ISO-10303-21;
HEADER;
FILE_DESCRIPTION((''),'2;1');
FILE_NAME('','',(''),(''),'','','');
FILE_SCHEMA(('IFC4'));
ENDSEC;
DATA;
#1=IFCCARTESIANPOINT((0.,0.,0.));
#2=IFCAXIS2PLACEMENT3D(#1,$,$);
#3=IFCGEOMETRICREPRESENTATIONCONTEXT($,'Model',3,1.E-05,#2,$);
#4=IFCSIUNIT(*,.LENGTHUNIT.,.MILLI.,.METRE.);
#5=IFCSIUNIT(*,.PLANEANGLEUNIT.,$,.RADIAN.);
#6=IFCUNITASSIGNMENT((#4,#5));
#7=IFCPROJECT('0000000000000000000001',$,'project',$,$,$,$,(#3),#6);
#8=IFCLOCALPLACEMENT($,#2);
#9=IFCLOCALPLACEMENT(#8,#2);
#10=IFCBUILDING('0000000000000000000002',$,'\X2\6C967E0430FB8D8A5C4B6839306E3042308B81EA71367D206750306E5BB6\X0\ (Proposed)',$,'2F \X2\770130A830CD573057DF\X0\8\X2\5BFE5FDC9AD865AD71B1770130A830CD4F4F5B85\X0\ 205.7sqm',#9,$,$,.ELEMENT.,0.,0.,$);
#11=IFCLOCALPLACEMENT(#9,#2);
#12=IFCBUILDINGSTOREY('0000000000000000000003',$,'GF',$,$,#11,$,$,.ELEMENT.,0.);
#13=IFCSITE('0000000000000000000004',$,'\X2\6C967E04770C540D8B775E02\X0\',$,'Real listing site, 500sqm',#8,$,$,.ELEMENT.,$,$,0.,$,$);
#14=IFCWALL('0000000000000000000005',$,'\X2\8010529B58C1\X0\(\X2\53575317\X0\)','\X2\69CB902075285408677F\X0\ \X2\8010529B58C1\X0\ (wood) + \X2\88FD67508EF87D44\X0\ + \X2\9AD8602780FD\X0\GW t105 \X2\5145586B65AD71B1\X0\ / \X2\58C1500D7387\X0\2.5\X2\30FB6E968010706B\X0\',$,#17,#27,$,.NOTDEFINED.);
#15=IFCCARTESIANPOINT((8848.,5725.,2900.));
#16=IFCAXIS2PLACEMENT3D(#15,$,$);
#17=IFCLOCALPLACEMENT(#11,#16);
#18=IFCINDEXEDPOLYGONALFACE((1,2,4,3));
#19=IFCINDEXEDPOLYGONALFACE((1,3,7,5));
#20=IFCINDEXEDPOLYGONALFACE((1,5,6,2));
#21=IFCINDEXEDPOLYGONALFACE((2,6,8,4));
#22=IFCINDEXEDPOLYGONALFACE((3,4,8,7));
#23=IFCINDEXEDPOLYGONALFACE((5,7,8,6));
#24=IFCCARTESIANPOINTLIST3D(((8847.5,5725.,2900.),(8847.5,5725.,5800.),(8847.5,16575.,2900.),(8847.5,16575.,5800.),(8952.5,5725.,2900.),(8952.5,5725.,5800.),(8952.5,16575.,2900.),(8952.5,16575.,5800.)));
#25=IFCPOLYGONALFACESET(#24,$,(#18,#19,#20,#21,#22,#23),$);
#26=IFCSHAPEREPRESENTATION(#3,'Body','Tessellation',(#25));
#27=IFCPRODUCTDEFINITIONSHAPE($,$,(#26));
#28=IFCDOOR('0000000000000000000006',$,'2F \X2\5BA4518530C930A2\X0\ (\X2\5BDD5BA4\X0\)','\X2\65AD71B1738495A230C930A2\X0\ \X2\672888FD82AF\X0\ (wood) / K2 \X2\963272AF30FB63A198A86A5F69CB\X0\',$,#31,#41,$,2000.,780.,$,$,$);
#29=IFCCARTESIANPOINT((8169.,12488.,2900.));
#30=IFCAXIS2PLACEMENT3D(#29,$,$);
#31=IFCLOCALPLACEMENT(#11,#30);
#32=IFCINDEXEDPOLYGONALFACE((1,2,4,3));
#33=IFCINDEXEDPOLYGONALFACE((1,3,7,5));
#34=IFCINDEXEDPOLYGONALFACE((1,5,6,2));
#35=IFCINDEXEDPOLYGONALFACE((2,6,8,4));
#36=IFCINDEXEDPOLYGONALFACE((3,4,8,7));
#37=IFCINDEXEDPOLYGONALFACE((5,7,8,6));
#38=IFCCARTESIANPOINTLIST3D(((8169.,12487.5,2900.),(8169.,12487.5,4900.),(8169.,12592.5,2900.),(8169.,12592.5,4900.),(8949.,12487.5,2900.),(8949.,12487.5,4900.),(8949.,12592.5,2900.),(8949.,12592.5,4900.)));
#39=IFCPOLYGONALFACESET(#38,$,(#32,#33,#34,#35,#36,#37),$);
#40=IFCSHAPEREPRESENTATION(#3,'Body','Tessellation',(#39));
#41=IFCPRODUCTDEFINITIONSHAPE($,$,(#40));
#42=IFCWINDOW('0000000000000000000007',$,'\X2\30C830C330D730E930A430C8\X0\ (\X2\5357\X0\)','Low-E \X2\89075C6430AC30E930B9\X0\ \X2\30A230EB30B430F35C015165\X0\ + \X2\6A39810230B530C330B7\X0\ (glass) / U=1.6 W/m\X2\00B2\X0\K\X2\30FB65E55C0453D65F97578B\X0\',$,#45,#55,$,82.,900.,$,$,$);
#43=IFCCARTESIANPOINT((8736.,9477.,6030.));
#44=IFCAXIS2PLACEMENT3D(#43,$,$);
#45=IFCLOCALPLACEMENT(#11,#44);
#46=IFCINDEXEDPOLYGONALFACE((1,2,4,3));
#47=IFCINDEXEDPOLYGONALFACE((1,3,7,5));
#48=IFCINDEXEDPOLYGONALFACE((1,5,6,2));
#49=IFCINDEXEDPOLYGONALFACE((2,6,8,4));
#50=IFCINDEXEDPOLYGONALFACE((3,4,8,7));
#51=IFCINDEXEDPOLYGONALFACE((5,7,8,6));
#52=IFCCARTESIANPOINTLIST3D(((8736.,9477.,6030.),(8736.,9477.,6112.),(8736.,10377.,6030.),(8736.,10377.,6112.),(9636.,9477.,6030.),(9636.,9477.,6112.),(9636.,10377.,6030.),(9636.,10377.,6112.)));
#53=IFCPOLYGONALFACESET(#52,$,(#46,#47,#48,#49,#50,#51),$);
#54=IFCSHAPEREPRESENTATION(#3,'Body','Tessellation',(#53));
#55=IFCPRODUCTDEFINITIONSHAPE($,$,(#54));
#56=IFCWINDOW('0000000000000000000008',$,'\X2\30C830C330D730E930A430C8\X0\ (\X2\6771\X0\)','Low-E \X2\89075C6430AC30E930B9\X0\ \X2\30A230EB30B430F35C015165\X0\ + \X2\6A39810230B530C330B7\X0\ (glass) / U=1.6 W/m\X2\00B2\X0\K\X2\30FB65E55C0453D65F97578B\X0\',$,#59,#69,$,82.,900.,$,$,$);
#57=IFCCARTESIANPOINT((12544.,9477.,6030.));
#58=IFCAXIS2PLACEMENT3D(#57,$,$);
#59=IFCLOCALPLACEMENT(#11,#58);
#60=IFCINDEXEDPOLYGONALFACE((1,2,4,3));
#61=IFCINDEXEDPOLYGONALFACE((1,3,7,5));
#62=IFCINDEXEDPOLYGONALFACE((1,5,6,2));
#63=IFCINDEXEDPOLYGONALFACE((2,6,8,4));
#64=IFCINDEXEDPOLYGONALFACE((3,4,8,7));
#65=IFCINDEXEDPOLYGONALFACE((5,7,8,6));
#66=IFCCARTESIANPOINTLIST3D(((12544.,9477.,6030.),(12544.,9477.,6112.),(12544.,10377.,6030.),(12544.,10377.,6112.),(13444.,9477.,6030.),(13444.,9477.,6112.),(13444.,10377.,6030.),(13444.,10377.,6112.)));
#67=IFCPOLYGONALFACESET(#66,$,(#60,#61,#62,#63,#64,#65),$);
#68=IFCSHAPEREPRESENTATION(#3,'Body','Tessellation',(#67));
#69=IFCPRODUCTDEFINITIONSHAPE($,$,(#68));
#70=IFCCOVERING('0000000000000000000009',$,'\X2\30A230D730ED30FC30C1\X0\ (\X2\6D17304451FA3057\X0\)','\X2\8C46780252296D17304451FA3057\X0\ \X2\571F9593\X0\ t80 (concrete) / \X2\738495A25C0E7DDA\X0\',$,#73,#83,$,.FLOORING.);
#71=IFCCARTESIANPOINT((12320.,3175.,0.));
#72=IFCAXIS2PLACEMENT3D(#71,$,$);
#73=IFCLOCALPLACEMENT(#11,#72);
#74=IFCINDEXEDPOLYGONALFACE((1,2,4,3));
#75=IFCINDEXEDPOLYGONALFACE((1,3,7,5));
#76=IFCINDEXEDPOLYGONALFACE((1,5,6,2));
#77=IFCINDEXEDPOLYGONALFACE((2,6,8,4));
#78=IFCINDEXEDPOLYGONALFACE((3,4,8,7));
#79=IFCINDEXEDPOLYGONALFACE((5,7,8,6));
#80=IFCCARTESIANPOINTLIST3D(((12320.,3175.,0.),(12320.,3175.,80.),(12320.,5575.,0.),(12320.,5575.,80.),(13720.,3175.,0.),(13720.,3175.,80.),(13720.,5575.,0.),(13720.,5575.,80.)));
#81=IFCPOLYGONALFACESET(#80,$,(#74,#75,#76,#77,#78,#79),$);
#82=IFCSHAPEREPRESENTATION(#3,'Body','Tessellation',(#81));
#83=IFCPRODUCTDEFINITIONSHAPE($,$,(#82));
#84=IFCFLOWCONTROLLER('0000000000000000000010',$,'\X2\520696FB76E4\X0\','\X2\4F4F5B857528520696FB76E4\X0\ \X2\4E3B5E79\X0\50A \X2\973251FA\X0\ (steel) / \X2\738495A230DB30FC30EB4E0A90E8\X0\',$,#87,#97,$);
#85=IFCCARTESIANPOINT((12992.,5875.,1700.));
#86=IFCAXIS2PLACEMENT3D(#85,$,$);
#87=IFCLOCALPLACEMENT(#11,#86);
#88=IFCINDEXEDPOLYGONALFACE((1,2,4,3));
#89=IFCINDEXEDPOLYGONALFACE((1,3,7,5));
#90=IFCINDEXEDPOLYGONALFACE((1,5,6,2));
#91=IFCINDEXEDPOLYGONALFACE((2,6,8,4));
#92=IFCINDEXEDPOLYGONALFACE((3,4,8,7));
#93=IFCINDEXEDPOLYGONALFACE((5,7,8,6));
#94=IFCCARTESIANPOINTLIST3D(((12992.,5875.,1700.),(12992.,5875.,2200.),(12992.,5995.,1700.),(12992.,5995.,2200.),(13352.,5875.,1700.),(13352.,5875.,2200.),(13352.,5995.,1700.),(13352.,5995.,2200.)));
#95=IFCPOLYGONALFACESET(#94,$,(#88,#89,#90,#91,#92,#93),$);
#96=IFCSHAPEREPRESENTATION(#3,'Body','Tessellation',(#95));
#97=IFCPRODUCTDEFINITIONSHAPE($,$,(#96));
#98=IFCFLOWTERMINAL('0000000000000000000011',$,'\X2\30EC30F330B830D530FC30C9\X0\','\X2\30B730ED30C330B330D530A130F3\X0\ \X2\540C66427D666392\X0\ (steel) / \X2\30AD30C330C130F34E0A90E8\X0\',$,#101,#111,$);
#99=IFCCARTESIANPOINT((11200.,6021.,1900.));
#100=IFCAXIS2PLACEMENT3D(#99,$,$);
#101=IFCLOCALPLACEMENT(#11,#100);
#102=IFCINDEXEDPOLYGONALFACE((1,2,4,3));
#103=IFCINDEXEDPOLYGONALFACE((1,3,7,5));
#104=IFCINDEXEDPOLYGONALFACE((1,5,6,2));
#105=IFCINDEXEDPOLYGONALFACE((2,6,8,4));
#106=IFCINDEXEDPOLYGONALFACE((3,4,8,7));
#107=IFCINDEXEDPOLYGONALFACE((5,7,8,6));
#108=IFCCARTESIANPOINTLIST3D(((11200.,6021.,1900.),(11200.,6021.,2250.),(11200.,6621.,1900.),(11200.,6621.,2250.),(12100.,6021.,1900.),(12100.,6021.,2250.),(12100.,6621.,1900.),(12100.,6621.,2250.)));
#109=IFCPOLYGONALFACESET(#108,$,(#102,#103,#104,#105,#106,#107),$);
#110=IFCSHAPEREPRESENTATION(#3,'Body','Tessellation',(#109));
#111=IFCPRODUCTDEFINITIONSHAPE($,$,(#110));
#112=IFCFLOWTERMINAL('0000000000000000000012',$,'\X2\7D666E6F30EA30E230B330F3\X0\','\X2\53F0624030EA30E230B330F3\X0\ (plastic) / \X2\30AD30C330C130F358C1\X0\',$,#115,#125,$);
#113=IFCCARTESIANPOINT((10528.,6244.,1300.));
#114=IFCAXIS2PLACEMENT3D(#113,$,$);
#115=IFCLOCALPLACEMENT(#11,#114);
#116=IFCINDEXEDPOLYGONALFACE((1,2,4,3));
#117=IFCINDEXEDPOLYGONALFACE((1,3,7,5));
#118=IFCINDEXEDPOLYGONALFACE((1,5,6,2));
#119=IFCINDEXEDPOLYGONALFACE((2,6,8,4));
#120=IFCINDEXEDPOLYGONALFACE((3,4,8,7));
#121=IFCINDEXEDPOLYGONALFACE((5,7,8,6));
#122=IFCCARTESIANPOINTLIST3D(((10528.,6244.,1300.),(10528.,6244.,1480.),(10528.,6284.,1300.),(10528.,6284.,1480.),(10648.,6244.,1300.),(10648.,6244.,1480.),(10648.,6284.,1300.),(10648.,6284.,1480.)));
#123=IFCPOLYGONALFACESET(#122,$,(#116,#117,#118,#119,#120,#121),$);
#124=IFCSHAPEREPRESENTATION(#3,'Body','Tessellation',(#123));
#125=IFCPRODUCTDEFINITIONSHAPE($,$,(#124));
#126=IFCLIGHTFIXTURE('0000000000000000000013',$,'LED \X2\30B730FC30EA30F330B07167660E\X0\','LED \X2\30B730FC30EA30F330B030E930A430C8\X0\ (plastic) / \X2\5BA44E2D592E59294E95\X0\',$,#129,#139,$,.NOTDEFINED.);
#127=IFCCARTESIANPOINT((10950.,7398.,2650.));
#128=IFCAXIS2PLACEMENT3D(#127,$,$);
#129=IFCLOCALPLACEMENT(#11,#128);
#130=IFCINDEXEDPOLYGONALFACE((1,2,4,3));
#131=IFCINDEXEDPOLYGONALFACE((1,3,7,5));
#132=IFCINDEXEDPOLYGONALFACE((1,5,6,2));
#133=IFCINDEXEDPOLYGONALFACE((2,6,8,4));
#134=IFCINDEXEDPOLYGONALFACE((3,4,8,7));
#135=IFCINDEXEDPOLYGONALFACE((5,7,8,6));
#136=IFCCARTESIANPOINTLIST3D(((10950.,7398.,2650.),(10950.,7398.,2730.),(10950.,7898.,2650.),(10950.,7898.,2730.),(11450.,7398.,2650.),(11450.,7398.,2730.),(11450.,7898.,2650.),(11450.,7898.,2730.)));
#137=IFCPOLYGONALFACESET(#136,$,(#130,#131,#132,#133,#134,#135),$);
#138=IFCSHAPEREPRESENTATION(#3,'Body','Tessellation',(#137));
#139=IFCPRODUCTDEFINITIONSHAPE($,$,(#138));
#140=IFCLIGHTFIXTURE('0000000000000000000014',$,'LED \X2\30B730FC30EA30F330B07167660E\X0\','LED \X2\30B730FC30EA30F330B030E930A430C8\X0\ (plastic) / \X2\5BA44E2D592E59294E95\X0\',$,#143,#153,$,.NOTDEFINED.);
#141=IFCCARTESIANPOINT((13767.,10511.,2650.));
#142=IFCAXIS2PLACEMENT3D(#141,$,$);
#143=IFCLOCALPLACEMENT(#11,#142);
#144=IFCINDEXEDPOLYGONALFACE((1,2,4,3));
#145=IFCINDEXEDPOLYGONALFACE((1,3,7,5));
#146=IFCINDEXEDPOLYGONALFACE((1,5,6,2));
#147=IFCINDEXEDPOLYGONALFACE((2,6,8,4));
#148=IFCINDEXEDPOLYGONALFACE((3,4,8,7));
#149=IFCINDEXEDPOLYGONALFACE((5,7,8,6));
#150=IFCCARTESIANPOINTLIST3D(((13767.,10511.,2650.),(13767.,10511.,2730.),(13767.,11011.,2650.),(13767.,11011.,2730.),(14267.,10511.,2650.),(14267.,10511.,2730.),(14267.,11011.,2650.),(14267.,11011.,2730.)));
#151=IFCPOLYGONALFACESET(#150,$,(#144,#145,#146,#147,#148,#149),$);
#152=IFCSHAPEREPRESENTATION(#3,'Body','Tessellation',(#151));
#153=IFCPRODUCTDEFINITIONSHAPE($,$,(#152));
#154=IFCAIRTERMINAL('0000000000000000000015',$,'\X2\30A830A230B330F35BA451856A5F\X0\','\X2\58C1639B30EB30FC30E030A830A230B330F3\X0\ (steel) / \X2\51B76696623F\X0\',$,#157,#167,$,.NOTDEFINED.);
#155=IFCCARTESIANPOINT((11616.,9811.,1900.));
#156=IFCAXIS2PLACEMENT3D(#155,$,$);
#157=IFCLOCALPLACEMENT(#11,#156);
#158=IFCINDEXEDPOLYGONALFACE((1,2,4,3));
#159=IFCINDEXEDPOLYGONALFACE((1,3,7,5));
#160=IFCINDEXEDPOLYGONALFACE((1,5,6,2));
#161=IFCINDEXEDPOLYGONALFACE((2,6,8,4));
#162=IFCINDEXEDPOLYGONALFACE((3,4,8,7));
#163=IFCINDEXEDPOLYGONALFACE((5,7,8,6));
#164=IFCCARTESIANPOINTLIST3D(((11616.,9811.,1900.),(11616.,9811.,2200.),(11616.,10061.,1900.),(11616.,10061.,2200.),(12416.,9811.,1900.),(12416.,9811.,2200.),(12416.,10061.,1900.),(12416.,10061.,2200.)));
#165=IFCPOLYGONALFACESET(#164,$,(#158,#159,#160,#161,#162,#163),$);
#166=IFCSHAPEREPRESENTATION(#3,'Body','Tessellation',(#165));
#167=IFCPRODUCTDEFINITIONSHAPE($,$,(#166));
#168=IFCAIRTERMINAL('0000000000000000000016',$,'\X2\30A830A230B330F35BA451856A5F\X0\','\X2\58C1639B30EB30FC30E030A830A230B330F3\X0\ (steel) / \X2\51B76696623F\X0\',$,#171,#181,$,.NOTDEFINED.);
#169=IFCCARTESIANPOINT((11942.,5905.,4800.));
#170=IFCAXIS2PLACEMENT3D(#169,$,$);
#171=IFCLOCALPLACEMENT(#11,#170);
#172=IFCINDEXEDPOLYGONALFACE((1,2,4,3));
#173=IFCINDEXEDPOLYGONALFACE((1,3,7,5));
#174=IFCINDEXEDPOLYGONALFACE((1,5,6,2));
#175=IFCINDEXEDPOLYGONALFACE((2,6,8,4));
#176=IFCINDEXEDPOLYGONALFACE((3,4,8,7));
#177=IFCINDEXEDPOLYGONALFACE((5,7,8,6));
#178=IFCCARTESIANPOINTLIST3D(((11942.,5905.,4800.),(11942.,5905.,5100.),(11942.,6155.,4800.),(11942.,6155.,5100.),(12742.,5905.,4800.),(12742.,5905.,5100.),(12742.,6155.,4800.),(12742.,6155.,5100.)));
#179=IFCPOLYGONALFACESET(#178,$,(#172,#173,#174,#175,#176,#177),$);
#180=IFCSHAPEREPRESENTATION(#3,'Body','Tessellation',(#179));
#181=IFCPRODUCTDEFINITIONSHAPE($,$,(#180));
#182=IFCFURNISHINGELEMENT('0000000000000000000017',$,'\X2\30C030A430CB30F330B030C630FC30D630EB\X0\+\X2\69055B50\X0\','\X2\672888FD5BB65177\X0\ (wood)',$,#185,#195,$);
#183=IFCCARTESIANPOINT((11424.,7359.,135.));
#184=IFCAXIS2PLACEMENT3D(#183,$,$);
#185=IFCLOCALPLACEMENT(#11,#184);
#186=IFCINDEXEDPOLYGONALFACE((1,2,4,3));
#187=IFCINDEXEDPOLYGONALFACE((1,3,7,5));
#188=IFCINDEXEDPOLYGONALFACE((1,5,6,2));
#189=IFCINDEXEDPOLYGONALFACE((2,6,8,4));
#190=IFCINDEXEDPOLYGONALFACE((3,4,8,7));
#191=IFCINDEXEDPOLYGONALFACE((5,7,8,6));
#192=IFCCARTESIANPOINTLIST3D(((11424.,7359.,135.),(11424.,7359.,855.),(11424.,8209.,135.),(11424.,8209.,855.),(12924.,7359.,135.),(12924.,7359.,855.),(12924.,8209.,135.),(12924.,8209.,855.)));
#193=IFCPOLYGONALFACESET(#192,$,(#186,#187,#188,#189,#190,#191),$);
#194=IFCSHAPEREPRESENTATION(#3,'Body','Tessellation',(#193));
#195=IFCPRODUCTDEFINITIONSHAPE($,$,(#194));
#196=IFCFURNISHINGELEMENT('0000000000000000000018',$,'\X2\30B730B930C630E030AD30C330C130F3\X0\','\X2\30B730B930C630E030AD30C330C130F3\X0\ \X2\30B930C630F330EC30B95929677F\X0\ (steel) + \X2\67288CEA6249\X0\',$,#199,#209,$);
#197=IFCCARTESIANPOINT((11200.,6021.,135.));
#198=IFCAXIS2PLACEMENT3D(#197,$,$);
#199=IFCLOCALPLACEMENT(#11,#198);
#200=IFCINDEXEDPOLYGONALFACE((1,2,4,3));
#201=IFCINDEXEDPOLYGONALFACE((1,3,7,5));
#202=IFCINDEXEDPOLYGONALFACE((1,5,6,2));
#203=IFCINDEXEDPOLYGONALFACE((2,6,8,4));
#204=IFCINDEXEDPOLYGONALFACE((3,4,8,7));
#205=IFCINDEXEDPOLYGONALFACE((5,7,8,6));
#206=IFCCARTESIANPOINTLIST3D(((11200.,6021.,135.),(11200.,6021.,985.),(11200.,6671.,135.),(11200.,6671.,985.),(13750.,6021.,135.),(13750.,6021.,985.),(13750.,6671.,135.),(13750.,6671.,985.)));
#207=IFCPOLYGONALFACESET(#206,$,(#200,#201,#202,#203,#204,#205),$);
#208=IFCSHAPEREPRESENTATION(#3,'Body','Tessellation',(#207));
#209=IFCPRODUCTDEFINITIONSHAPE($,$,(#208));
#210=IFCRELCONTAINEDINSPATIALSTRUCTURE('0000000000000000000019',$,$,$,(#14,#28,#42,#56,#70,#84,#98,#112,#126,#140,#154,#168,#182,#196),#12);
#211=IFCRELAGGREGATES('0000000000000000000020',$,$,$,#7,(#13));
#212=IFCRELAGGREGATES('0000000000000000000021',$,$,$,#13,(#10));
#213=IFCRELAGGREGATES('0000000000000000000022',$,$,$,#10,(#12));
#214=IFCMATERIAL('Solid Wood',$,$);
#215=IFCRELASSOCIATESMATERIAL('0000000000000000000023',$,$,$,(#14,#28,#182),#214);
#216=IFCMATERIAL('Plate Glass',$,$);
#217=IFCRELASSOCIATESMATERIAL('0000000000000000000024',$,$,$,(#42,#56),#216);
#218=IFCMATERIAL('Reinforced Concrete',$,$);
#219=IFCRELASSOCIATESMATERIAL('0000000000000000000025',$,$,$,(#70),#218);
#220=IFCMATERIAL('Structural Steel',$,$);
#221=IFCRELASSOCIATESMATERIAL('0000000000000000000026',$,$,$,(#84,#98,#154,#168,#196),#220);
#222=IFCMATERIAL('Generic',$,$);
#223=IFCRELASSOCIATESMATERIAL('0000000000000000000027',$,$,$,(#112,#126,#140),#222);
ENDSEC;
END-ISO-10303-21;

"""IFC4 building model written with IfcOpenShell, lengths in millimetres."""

from ifc_helpers import new_model, si_unit, frame, frame_2d, origin, place, context, project, spatial, rectangle, extrude, material, element, fill, save


model = new_model("IFC4")

# Units and contexts
model_context = context("Model", 3, precision=1e-05, world=origin())
ifc_project = project(units=[si_unit("LENGTHUNIT", "METRE", prefix="MILLI"), si_unit("PLANEANGLEUNIT", "RADIAN")], contexts=[model_context])

# Site, building, storey
site_placement = place(None, origin())
site = spatial("IfcSite", under=ifc_project, at=site_placement, Name="沖縄県名護市", ObjectType="Real listing site, 500sqm", CompositionType="ELEMENT", RefElevation=0.0)
building_placement = place(site_placement, origin())
building = spatial("IfcBuilding", under=site, at=building_placement, Name="沖縄・越屋根のある自然素材の家 (Proposed)", ObjectType="2F 省エネ地域8対応高断熱省エネ住宅 205.7sqm", CompositionType="ELEMENT", ElevationOfRefHeight=0.0, ElevationOfTerrain=0.0)
storey_placement = place(building_placement, origin())
storey = spatial("IfcBuildingStorey", under=building, at=storey_placement, Name="GF", CompositionType="ELEMENT", Elevation=0.0)

# Shared definitions
ifc_material_1 = material(Name="Solid Wood")

# Wall, opening, door
wall_1_placement = place(storey_placement, frame((8848.0, 5725.0, 2900.0)))
wall_1 = element("IfcWall", 1, at=wall_1_placement, inside=storey, material=ifc_material_1, Name="耐力壁(南北)", Description="構造用合板 耐力壁 (wood) + 製材軸組 + 高性能GW t105 充填断熱 / 壁倍率2.5・準耐火", PredefinedType="NOTDEFINED", context=model_context, shape_type="SweptSolid", body=[
    extrude(rectangle(XDim=105.0, YDim=10850.0, at=frame_2d((52.0, 5425.0))), frame((8848.0, 5725.0, 2900.0)), (0.0, 0.0, 1.0), 2900.0),
])
opening_1_placement = place(storey_placement, frame((8169.0, 12488.0, 2900.0)))
opening_1 = element("IfcOpeningElement", 2, at=opening_1_placement, cuts=wall_1, PredefinedType="NOTDEFINED", context=model_context, shape_type="SweptSolid", body=[
    extrude(rectangle(XDim=780.0, YDim=105.0, at=frame_2d((390.0, 52.0))), frame((8169.0, 12488.0, 2900.0)), (0.0, 0.0, 1.0), 2000.0),
])
door_1_placement = place(storey_placement, frame((8169.0, 12488.0, 2900.0)))
door_1 = element("IfcDoor", 3, at=door_1_placement, inside=storey, material=ifc_material_1, Name="2F 室内ドア (寝室)", Description="断熱玄関ドア 木製芯 (wood) / K2 防犯・採風機構", OverallHeight=2000.0, OverallWidth=780.0, context=model_context, shape_type="SweptSolid", body=[
    extrude(rectangle(XDim=780.0, YDim=105.0, at=frame_2d((390.0, 52.0))), frame((8169.0, 12488.0, 2900.0)), (0.0, 0.0, 1.0), 2000.0),
])
fill(opening_1, door_1)

# Windows
ifc_material_2 = material(Name="Plate Glass")
window_1_placement = place(storey_placement, frame((8736.0, 9477.0, 6030.0)))
element("IfcWindow", 4, at=window_1_placement, inside=storey, material=ifc_material_2, Name="トップライト (南)", Description="Low-E 複層ガラス アルゴン封入 + 樹脂サッシ (glass) / U=1.6 W/m²K・日射取得型", OverallHeight=82.0, OverallWidth=900.0, context=model_context, shape_type="SweptSolid", body=[
    extrude(rectangle(XDim=900.0, YDim=900.0, at=frame_2d((450.0, 450.0))), frame((8736.0, 9477.0, 6030.0)), (0.0, 0.0, 1.0), 82.0),
])
window_2_placement = place(storey_placement, frame((12544.0, 9477.0, 6030.0)))
element("IfcWindow", 5, at=window_2_placement, inside=storey, material=ifc_material_2, Name="トップライト (東)", Description="Low-E 複層ガラス アルゴン封入 + 樹脂サッシ (glass) / U=1.6 W/m²K・日射取得型", OverallHeight=82.0, OverallWidth=900.0, context=model_context, shape_type="SweptSolid", body=[
    extrude(rectangle(XDim=900.0, YDim=900.0, at=frame_2d((450.0, 450.0))), frame((12544.0, 9477.0, 6030.0)), (0.0, 0.0, 1.0), 82.0),
])

# Covering
ifc_material_3 = material(Name="Reinforced Concrete")
covering_placement = place(storey_placement, frame((12320.0, 3175.0, 0.0)))
element("IfcCovering", 6, at=covering_placement, inside=storey, material=ifc_material_3, Name="アプローチ (洗い出し)", Description="豆砂利洗い出し 土間 t80 (concrete) / 玄関導線", PredefinedType="FLOORING", context=model_context, shape_type="SweptSolid", body=[
    extrude(rectangle(XDim=1400.0, YDim=2400.0, at=frame_2d((700.0, 1200.0))), frame((12320.0, 3175.0, 0.0)), (0.0, 0.0, 1.0), 80.0),
])

# Flow controller
ifc_material_4 = material(Name="Structural Steel")
flow_controller_placement = place(storey_placement, frame((12992.0, 5875.0, 1700.0)))
element("IfcFlowController", 7, at=flow_controller_placement, inside=storey, material=ifc_material_4, Name="分電盤", Description="住宅用分電盤 主幹50A 露出 (steel) / 玄関ホール上部", context=model_context, shape_type="SweptSolid", body=[
    extrude(rectangle(XDim=360.0, YDim=120.0, at=frame_2d((180.0, 60.0))), frame((12992.0, 5875.0, 1700.0)), (0.0, 0.0, 1.0), 500.0),
])

# Flow terminals
flow_terminal_1_placement = place(storey_placement, frame((11200.0, 6021.0, 1900.0)))
element("IfcFlowTerminal", 8, at=flow_terminal_1_placement, inside=storey, material=ifc_material_4, Name="レンジフード", Description="シロッコファン 同時給排 (steel) / キッチン上部", context=model_context, shape_type="SweptSolid", body=[
    extrude(rectangle(XDim=900.0, YDim=600.0, at=frame_2d((450.0, 300.0))), frame((11200.0, 6021.0, 1900.0)), (0.0, 0.0, 1.0), 350.0),
])
ifc_material_5 = material(Name="Generic")
flow_terminal_2_placement = place(storey_placement, frame((10528.0, 6244.0, 1300.0)))
element("IfcFlowTerminal", 9, at=flow_terminal_2_placement, inside=storey, material=ifc_material_5, Name="給湯リモコン", Description="台所リモコン (plastic) / キッチン壁", context=model_context, shape_type="SweptSolid", body=[
    extrude(rectangle(XDim=120.0, YDim=40.0, at=frame_2d((60.0, 20.0))), frame((10528.0, 6244.0, 1300.0)), (0.0, 0.0, 1.0), 180.0),
])

# Light fixtures
light_fixture_1_placement = place(storey_placement, frame((10950.0, 7398.0, 2650.0)))
element("IfcLightFixture", 10, at=light_fixture_1_placement, inside=storey, material=ifc_material_5, Name="LED シーリング照明", Description="LED シーリングライト (plastic) / 室中央天井", PredefinedType="NOTDEFINED", context=model_context, shape_type="SweptSolid", body=[
    extrude(rectangle(XDim=500.0, YDim=500.0, at=frame_2d((250.0, 250.0))), frame((10950.0, 7398.0, 2650.0)), (0.0, 0.0, 1.0), 80.0),
])
light_fixture_2_placement = place(storey_placement, frame((13767.0, 10511.0, 2650.0)))
element("IfcLightFixture", 11, at=light_fixture_2_placement, inside=storey, material=ifc_material_5, Name="LED シーリング照明", Description="LED シーリングライト (plastic) / 室中央天井", PredefinedType="NOTDEFINED", context=model_context, shape_type="SweptSolid", body=[
    extrude(rectangle(XDim=500.0, YDim=500.0, at=frame_2d((250.0, 250.0))), frame((13767.0, 10511.0, 2650.0)), (0.0, 0.0, 1.0), 80.0),
])

# Air terminals
air_terminal_1_placement = place(storey_placement, frame((11616.0, 9811.0, 1900.0)))
element("IfcAirTerminal", 12, at=air_terminal_1_placement, inside=storey, material=ifc_material_4, Name="エアコン室内機", Description="壁掛ルームエアコン (steel) / 冷暖房", PredefinedType="NOTDEFINED", context=model_context, shape_type="SweptSolid", body=[
    extrude(rectangle(XDim=800.0, YDim=250.0, at=frame_2d((400.0, 125.0))), frame((11616.0, 9811.0, 1900.0)), (0.0, 0.0, 1.0), 300.0),
])
air_terminal_2_placement = place(storey_placement, frame((11942.0, 5905.0, 4800.0)))
element("IfcAirTerminal", 13, at=air_terminal_2_placement, inside=storey, material=ifc_material_4, Name="エアコン室内機", Description="壁掛ルームエアコン (steel) / 冷暖房", PredefinedType="NOTDEFINED", context=model_context, shape_type="SweptSolid", body=[
    extrude(rectangle(XDim=800.0, YDim=250.0, at=frame_2d((400.0, 125.0))), frame((11942.0, 5905.0, 4800.0)), (0.0, 0.0, 1.0), 300.0),
])

# Furnishing elements
furnishing_1_placement = place(storey_placement, frame((11424.0, 7359.0, 135.0)))
element("IfcFurnishingElement", 14, at=furnishing_1_placement, inside=storey, material=ifc_material_1, Name="ダイニングテーブル+椅子", Description="木製家具 (wood)", context=model_context, shape_type="SweptSolid", body=[
    extrude(rectangle(XDim=1500.0, YDim=850.0, at=frame_2d((750.0, 425.0))), frame((11424.0, 7359.0, 135.0)), (0.0, 0.0, 1.0), 720.0),
])
furnishing_2_placement = place(storey_placement, frame((11200.0, 6021.0, 135.0)))
element("IfcFurnishingElement", 15, at=furnishing_2_placement, inside=storey, material=ifc_material_4, Name="システムキッチン", Description="システムキッチン ステンレス天板 (steel) + 木質扉", context=model_context, shape_type="SweptSolid", body=[
    extrude(rectangle(XDim=2550.0, YDim=650.0, at=frame_2d((1275.0, 325.0))), frame((11200.0, 6021.0, 135.0)), (0.0, 0.0, 1.0), 850.0),
])

save(model, "model.ifc")
